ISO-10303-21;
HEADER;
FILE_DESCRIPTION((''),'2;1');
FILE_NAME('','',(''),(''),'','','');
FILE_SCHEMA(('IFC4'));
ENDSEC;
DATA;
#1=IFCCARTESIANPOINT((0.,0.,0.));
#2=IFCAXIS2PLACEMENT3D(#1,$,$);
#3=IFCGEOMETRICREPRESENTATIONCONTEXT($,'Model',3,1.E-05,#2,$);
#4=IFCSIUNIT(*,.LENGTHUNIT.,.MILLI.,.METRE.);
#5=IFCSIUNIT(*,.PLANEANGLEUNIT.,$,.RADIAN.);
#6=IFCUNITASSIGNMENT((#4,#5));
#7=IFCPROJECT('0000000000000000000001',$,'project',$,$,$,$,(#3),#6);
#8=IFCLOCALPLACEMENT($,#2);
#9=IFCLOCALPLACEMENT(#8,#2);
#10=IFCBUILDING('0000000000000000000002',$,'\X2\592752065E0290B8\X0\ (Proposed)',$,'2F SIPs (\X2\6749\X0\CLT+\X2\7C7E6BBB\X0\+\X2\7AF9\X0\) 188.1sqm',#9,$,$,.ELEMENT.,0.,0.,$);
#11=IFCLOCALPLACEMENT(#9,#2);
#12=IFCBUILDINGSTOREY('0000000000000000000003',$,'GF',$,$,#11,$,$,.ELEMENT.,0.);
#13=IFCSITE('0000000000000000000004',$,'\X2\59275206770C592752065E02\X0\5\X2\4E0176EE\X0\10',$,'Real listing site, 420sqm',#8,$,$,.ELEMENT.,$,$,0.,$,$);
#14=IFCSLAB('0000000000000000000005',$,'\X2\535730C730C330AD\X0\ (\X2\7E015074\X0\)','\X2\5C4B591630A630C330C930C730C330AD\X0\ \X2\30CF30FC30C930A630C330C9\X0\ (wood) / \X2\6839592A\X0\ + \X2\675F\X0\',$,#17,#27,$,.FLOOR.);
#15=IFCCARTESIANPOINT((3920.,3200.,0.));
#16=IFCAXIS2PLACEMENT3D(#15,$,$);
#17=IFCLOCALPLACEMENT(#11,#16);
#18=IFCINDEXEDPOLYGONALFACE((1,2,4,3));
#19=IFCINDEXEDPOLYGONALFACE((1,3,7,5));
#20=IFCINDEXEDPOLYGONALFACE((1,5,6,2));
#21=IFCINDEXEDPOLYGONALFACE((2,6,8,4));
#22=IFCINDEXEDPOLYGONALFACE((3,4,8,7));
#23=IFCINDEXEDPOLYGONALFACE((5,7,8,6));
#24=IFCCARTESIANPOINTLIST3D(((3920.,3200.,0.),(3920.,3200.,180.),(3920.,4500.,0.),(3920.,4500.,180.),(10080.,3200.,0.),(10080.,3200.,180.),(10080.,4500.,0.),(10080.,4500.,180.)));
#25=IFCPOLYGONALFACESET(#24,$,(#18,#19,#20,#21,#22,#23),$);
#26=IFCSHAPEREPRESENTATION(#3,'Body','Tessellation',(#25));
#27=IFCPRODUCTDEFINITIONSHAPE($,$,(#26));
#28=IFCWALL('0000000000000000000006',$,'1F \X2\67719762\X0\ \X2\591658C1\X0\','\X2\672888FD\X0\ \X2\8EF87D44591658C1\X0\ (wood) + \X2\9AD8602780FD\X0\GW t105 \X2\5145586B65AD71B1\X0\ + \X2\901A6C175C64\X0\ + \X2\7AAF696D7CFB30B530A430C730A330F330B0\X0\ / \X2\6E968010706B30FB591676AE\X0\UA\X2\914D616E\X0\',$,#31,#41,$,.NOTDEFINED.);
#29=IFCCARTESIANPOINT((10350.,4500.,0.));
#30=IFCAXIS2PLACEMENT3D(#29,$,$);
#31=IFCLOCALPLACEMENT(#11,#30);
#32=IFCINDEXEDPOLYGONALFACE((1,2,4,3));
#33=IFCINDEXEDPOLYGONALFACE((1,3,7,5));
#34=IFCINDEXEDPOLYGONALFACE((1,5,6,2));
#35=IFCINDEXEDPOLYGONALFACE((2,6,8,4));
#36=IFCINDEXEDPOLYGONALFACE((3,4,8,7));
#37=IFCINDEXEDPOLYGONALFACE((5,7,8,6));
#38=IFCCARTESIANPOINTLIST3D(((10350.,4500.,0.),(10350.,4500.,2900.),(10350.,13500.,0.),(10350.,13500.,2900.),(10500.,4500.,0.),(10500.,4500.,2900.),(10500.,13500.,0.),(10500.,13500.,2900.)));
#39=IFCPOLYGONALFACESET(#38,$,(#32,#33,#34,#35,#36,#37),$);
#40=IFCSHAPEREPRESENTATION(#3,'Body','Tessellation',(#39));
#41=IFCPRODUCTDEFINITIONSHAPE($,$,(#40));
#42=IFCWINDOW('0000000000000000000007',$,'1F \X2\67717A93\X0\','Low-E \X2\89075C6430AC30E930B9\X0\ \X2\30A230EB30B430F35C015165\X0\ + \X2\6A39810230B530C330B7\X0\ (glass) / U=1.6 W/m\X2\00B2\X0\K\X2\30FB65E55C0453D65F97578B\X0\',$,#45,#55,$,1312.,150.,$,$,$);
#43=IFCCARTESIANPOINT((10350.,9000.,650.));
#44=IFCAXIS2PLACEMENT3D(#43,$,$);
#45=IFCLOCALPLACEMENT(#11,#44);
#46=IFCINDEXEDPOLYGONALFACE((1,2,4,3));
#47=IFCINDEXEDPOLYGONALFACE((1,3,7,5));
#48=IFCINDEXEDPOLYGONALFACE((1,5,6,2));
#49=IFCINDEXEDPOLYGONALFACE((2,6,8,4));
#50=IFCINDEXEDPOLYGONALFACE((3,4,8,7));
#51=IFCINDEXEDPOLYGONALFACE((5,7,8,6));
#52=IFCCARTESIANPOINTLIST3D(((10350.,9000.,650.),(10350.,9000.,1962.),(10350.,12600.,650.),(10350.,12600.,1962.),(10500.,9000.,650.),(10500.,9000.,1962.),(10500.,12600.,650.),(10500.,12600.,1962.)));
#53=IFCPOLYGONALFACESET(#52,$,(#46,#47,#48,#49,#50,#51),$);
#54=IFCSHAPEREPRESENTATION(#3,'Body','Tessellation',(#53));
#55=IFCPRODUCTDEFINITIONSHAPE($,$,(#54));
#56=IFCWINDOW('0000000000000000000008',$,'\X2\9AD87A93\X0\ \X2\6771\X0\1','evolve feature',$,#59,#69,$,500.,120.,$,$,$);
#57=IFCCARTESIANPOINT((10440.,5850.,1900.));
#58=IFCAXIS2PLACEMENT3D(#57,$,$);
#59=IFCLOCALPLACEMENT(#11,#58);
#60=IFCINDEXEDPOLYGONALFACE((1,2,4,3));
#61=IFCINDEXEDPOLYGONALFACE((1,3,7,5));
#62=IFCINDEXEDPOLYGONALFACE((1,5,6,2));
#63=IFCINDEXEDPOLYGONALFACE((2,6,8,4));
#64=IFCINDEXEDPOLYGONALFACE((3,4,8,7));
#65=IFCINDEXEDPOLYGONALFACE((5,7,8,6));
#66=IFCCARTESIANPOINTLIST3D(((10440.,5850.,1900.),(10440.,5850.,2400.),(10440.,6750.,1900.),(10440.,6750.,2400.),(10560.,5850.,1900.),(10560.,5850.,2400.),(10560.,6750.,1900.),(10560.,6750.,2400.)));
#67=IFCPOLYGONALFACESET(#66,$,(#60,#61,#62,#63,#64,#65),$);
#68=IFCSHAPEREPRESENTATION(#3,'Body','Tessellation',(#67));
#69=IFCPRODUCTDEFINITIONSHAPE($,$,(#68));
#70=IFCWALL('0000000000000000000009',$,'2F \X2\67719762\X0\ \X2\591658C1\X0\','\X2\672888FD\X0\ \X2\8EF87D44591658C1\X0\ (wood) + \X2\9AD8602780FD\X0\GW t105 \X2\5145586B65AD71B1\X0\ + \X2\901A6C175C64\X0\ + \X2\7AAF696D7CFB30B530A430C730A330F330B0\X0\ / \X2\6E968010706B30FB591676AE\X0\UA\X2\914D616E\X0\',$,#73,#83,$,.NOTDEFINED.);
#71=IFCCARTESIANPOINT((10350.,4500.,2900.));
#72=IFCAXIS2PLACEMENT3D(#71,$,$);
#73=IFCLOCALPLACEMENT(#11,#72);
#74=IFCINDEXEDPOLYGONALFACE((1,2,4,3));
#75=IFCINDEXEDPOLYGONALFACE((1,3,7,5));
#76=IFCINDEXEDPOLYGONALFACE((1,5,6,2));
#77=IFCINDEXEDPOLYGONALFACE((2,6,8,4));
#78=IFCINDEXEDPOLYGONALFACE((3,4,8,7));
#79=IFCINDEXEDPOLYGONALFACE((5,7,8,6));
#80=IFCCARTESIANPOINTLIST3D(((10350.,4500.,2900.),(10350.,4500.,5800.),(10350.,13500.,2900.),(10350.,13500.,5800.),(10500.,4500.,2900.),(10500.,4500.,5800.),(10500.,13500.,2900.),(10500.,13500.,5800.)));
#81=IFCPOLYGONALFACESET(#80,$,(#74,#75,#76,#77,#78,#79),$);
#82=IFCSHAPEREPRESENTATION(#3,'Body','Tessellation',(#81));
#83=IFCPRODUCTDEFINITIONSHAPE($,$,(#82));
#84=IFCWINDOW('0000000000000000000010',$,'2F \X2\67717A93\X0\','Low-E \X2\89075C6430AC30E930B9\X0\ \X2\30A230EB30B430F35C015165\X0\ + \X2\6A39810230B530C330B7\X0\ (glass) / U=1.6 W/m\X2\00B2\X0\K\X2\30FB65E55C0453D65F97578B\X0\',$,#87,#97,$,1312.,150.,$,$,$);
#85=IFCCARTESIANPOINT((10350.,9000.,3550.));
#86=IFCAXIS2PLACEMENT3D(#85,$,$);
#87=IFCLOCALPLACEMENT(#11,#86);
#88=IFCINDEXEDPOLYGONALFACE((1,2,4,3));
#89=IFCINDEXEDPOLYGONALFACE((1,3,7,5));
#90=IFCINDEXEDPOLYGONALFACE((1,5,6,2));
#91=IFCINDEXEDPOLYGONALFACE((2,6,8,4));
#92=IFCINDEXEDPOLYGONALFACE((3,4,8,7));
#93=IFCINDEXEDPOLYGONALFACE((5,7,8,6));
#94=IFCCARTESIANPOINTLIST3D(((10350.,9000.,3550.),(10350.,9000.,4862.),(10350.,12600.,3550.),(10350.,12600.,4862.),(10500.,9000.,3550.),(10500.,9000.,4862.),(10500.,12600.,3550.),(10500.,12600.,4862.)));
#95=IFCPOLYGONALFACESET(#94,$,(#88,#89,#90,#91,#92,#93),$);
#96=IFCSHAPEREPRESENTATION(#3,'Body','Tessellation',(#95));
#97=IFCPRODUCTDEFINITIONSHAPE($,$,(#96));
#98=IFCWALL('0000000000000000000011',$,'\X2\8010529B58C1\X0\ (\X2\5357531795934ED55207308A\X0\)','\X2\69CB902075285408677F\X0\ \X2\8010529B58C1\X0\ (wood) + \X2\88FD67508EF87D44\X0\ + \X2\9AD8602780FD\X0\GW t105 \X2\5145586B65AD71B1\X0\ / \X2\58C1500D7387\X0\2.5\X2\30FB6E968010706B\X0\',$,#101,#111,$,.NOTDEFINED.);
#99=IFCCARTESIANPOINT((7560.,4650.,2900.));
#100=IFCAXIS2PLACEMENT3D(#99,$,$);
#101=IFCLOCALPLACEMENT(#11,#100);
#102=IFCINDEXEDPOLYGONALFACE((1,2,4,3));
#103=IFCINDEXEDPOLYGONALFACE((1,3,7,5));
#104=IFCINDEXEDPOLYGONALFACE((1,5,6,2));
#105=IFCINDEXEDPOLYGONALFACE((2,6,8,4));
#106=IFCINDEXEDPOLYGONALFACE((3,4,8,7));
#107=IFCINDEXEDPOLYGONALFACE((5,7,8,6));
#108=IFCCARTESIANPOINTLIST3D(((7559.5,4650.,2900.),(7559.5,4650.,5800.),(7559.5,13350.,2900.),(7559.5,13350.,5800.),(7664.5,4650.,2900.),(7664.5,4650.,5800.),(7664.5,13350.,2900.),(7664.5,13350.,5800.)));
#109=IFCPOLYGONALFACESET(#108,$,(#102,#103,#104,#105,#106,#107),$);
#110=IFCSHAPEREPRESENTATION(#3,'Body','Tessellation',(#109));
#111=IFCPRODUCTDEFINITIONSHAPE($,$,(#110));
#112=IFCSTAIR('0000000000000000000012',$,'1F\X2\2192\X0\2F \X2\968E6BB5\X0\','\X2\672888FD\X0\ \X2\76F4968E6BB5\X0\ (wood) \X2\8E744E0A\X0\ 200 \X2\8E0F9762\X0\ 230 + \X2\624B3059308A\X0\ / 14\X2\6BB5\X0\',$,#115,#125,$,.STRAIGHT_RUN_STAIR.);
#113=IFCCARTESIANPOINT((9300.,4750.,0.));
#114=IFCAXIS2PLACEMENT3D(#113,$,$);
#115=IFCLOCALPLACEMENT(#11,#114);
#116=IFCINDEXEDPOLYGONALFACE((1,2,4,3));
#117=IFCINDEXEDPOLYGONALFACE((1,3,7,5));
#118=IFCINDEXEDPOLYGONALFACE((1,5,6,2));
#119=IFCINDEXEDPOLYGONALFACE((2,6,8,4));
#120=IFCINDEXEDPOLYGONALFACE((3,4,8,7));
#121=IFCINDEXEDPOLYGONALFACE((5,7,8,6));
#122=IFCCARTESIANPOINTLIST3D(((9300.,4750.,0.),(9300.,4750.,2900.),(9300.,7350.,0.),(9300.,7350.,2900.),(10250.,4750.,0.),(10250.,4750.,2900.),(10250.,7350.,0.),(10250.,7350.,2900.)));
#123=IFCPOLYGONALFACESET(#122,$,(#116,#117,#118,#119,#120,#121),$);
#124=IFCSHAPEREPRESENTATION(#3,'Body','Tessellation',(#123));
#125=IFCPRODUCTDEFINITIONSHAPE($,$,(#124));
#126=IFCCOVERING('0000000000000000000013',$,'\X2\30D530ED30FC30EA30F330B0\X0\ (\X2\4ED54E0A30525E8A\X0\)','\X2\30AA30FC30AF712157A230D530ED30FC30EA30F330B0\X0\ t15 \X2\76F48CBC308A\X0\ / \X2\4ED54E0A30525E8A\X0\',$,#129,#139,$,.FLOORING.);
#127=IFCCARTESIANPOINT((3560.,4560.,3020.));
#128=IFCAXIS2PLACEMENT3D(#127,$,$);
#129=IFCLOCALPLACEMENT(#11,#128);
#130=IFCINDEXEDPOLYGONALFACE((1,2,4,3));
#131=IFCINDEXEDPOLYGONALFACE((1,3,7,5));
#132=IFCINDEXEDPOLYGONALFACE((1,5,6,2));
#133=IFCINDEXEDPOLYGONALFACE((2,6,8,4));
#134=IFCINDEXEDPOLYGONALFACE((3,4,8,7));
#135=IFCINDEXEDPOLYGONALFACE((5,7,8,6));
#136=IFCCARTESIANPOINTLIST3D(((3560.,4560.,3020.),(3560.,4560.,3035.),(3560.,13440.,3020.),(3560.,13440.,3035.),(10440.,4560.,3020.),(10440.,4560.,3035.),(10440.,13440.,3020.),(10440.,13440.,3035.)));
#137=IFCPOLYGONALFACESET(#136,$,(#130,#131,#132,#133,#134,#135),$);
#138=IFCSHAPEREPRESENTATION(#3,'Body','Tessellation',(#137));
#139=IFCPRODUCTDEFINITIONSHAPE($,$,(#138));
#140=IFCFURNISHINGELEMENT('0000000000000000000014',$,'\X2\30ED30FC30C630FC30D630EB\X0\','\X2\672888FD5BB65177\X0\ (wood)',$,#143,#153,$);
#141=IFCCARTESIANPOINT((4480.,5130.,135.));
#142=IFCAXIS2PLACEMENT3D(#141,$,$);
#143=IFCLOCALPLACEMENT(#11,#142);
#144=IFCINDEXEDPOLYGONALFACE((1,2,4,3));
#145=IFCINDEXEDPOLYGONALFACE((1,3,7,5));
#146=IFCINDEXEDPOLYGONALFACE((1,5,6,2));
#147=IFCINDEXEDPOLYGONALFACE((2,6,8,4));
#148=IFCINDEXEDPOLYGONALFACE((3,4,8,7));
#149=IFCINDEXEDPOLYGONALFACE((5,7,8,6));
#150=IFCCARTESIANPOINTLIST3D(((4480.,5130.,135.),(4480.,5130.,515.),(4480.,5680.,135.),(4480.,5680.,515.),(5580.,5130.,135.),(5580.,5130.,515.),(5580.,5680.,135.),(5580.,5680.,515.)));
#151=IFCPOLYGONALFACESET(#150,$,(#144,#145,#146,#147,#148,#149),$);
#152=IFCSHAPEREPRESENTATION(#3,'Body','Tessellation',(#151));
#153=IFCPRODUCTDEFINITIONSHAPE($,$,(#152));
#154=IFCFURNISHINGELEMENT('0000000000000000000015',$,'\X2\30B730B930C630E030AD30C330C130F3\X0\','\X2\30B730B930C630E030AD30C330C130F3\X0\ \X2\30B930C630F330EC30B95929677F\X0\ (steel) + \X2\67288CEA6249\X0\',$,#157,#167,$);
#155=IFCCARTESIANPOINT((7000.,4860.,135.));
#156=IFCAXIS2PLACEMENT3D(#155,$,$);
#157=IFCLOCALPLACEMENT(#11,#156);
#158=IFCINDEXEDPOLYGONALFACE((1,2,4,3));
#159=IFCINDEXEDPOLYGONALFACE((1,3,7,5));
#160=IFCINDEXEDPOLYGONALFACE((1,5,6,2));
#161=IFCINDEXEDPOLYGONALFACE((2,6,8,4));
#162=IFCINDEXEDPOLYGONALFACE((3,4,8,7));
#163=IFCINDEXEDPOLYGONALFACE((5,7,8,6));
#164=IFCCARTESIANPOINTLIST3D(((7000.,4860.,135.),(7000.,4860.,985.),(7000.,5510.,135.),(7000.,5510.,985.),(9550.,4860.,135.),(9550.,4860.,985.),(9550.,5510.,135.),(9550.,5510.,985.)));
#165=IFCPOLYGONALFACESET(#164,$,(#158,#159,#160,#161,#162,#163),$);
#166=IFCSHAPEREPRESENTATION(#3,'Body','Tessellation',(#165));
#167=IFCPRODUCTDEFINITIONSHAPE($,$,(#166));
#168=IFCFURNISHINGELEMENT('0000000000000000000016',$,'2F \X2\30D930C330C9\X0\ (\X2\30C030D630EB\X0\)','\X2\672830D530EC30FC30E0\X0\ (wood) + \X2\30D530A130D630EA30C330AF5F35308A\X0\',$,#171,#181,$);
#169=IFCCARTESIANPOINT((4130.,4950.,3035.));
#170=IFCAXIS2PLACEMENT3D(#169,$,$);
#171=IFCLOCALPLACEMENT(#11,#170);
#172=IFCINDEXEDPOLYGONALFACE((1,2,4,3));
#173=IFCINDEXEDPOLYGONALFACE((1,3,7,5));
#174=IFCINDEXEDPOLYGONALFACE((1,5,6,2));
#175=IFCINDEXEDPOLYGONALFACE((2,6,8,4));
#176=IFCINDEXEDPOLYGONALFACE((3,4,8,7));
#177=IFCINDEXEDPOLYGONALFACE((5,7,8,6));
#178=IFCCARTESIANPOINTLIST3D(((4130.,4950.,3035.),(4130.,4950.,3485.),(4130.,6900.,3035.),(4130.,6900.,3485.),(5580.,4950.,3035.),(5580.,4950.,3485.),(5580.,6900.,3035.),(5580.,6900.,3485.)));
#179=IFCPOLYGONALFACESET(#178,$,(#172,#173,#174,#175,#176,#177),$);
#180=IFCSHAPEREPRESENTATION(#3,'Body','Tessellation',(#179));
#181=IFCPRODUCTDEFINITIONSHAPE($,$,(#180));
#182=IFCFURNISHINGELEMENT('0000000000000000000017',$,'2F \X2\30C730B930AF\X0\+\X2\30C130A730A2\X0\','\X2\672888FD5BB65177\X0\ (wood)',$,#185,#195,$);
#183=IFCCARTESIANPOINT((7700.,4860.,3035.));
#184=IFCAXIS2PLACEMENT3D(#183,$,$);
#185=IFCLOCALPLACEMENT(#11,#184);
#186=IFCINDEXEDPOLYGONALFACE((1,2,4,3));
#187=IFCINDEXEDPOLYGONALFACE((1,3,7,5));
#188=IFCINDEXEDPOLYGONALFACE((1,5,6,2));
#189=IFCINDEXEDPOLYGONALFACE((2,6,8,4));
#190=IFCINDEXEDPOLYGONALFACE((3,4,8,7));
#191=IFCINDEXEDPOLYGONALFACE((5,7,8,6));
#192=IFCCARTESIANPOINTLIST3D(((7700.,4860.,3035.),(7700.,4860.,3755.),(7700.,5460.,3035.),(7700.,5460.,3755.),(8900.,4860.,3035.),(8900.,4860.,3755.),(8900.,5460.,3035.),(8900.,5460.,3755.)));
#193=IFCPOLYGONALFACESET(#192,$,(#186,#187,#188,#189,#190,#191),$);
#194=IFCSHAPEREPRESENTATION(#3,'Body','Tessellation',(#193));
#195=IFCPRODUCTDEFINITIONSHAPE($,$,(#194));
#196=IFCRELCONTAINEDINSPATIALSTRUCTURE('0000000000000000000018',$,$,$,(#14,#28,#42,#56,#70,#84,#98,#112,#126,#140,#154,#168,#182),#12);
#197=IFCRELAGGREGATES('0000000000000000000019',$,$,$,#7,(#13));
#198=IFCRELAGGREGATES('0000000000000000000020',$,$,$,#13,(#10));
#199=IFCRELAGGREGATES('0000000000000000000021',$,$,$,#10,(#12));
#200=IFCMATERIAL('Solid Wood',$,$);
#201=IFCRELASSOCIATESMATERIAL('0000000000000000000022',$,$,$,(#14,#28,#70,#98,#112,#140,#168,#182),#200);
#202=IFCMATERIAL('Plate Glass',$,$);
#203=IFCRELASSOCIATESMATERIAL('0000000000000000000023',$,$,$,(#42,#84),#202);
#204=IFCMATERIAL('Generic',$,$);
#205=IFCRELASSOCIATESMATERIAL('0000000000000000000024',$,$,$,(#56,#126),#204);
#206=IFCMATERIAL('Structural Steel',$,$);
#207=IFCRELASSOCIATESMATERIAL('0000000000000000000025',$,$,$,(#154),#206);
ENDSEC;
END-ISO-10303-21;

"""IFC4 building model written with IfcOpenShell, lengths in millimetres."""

from ifc_helpers import new_model, si_unit, frame, frame_2d, origin, place, context, project, spatial, rectangle, extrude, material, element, fill, save


model = new_model("IFC4")

# Units and contexts
model_context = context("Model", 3, precision=1e-05, world=origin())
ifc_project = project(units=[si_unit("LENGTHUNIT", "METRE", prefix="MILLI"), si_unit("PLANEANGLEUNIT", "RADIAN")], contexts=[model_context])

# Site, building, storey
site_placement = place(None, origin())
site = spatial("IfcSite", under=ifc_project, at=site_placement, Name="大分県大分市5丁目10", ObjectType="Real listing site, 420sqm", CompositionType="ELEMENT", RefElevation=0.0)
building_placement = place(site_placement, origin())
building = spatial("IfcBuilding", under=site, at=building_placement, Name="大分市邸 (Proposed)", ObjectType="2F SIPs (杉CLT+籾殻+竹) 188.1sqm", CompositionType="ELEMENT", ElevationOfRefHeight=0.0, ElevationOfTerrain=0.0)
storey_placement = place(building_placement, origin())
storey = spatial("IfcBuildingStorey", under=building, at=storey_placement, Name="GF", CompositionType="ELEMENT", Elevation=0.0)

# Slab
ifc_material_1 = material(Name="Solid Wood")
slab_placement = place(storey_placement, frame((3920.0, 3200.0, 0.0)))
element("IfcSlab", 1, at=slab_placement, inside=storey, material=ifc_material_1, Name="南デッキ (縁側)", Description="屋外ウッドデッキ ハードウッド (wood) / 根太 + 束", PredefinedType="FLOOR", context=model_context, shape_type="SweptSolid", body=[
    extrude(rectangle(XDim=6160.0, YDim=1300.0, at=frame_2d((3080.0, 650.0))), frame((3920.0, 3200.0, 0.0)), (0.0, 0.0, 1.0), 180.0),
])

# Wall, openings, windows
wall_1_placement = place(storey_placement, frame((10350.0, 4500.0, 0.0)))
wall_1 = element("IfcWall", 2, at=wall_1_placement, inside=storey, material=ifc_material_1, Name="1F 東面 外壁", Description="木製 軸組外壁 (wood) + 高性能GW t105 充填断熱 + 通気層 + 窯業系サイディング / 準耐火・外皮UA配慮", PredefinedType="NOTDEFINED", context=model_context, shape_type="SweptSolid", body=[
    extrude(rectangle(XDim=150.0, YDim=9000.0, at=frame_2d((75.0, 4500.0))), frame((10350.0, 4500.0, 0.0)), (0.0, 0.0, 1.0), 2900.0),
])
opening_1_placement = place(storey_placement, frame((10350.0, 9000.0, 650.0)))
opening_1 = element("IfcOpeningElement", 3, at=opening_1_placement, cuts=wall_1, PredefinedType="NOTDEFINED", context=model_context, shape_type="SweptSolid", body=[
    extrude(rectangle(XDim=150.0, YDim=3600.0, at=frame_2d((75.0, 1800.0))), frame((10350.0, 9000.0, 650.0)), (0.0, 0.0, 1.0), 1312.0),
])
opening_2_placement = place(storey_placement, frame((10440.0, 5850.0, 1900.0)))
opening_2 = element("IfcOpeningElement", 4, at=opening_2_placement, cuts=wall_1, PredefinedType="NOTDEFINED", context=model_context, shape_type="SweptSolid", body=[
    extrude(rectangle(XDim=120.0, YDim=900.0, at=frame_2d((60.0, 450.0))), frame((10440.0, 5850.0, 1900.0)), (0.0, 0.0, 1.0), 500.0),
])
ifc_material_2 = material(Name="Plate Glass")
window_1_placement = place(storey_placement, frame((10350.0, 9000.0, 650.0)))
window_1 = element("IfcWindow", 5, at=window_1_placement, inside=storey, material=ifc_material_2, Name="1F 東窓", Description="Low-E 複層ガラス アルゴン封入 + 樹脂サッシ (glass) / U=1.6 W/m²K・日射取得型", OverallHeight=1312.0, OverallWidth=150.0, context=model_context, shape_type="SweptSolid", body=[
    extrude(rectangle(XDim=150.0, YDim=3600.0, at=frame_2d((75.0, 1800.0))), frame((10350.0, 9000.0, 650.0)), (0.0, 0.0, 1.0), 1312.0),
])
fill(opening_1, window_1)
ifc_material_3 = material(Name="Generic")
window_2_placement = place(storey_placement, frame((10440.0, 5850.0, 1900.0)))
window_2 = element("IfcWindow", 6, at=window_2_placement, inside=storey, material=ifc_material_3, Name="高窓 東1", Description="evolve feature", OverallHeight=500.0, OverallWidth=120.0, context=model_context, shape_type="SweptSolid", body=[
    extrude(rectangle(XDim=120.0, YDim=900.0, at=frame_2d((60.0, 450.0))), frame((10440.0, 5850.0, 1900.0)), (0.0, 0.0, 1.0), 500.0),
])
fill(opening_2, window_2)

# Wall, opening, window
wall_2_placement = place(storey_placement, frame((10350.0, 4500.0, 2900.0)))
wall_2 = element("IfcWall", 7, at=wall_2_placement, inside=storey, material=ifc_material_1, Name="2F 東面 外壁", Description="木製 軸組外壁 (wood) + 高性能GW t105 充填断熱 + 通気層 + 窯業系サイディング / 準耐火・外皮UA配慮", PredefinedType="NOTDEFINED", context=model_context, shape_type="SweptSolid", body=[
    extrude(rectangle(XDim=150.0, YDim=9000.0, at=frame_2d((75.0, 4500.0))), frame((10350.0, 4500.0, 2900.0)), (0.0, 0.0, 1.0), 2900.0),
])
opening_3_placement = place(storey_placement, frame((10350.0, 9000.0, 3550.0)))
opening_3 = element("IfcOpeningElement", 8, at=opening_3_placement, cuts=wall_2, PredefinedType="NOTDEFINED", context=model_context, shape_type="SweptSolid", body=[
    extrude(rectangle(XDim=150.0, YDim=3600.0, at=frame_2d((75.0, 1800.0))), frame((10350.0, 9000.0, 3550.0)), (0.0, 0.0, 1.0), 1312.0),
])
window_3_placement = place(storey_placement, frame((10350.0, 9000.0, 3550.0)))
window_3 = element("IfcWindow", 9, at=window_3_placement, inside=storey, material=ifc_material_2, Name="2F 東窓", Description="Low-E 複層ガラス アルゴン封入 + 樹脂サッシ (glass) / U=1.6 W/m²K・日射取得型", OverallHeight=1312.0, OverallWidth=150.0, context=model_context, shape_type="SweptSolid", body=[
    extrude(rectangle(XDim=150.0, YDim=3600.0, at=frame_2d((75.0, 1800.0))), frame((10350.0, 9000.0, 3550.0)), (0.0, 0.0, 1.0), 1312.0),
])
fill(opening_3, window_3)

# Wall
wall_3_placement = place(storey_placement, frame((7560.0, 4650.0, 2900.0)))
element("IfcWall", 10, at=wall_3_placement, inside=storey, material=ifc_material_1, Name="耐力壁 (南北間仕切り)", Description="構造用合板 耐力壁 (wood) + 製材軸組 + 高性能GW t105 充填断熱 / 壁倍率2.5・準耐火", PredefinedType="NOTDEFINED", context=model_context, shape_type="SweptSolid", body=[
    extrude(rectangle(XDim=105.0, YDim=8700.0, at=frame_2d((52.0, 4350.0))), frame((7560.0, 4650.0, 2900.0)), (0.0, 0.0, 1.0), 2900.0),
])

# Stair
stair_placement = place(storey_placement, frame((9300.0, 4750.0, 0.0)))
element("IfcStair", 11, at=stair_placement, inside=storey, material=ifc_material_1, Name="1F→2F 階段", Description="木製 直階段 (wood) 蹴上 200 踏面 230 + 手すり / 14段", PredefinedType="STRAIGHT_RUN_STAIR", context=model_context, shape_type="SweptSolid", body=[
    extrude(rectangle(XDim=950.0, YDim=2600.0, at=frame_2d((475.0, 1300.0))), frame((9300.0, 4750.0, 0.0)), (0.0, 0.0, 1.0), 2900.0),
])

# Covering
covering_placement = place(storey_placement, frame((3560.0, 4560.0, 3020.0)))
element("IfcCovering", 12, at=covering_placement, inside=storey, material=ifc_material_3, Name="フローリング (仕上げ床)", Description="オーク無垢フローリング t15 直貼り / 仕上げ床", PredefinedType="FLOORING", context=model_context, shape_type="SweptSolid", body=[
    extrude(rectangle(XDim=6880.0, YDim=8880.0, at=frame_2d((3440.0, 4440.0))), frame((3560.0, 4560.0, 3020.0)), (0.0, 0.0, 1.0), 15.0),
])

# Furnishing elements
furnishing_1_placement = place(storey_placement, frame((4480.0, 5130.0, 135.0)))
element("IfcFurnishingElement", 13, at=furnishing_1_placement, inside=storey, material=ifc_material_1, Name="ローテーブル", Description="木製家具 (wood)", context=model_context, shape_type="SweptSolid", body=[
    extrude(rectangle(XDim=1100.0, YDim=550.0, at=frame_2d((550.0, 275.0))), frame((4480.0, 5130.0, 135.0)), (0.0, 0.0, 1.0), 380.0),
])
ifc_material_4 = material(Name="Structural Steel")
furnishing_2_placement = place(storey_placement, frame((7000.0, 4860.0, 135.0)))
element("IfcFurnishingElement", 14, at=furnishing_2_placement, inside=storey, material=ifc_material_4, Name="システムキッチン", Description="システムキッチン ステンレス天板 (steel) + 木質扉", context=model_context, shape_type="SweptSolid", body=[
    extrude(rectangle(XDim=2550.0, YDim=650.0, at=frame_2d((1275.0, 325.0))), frame((7000.0, 4860.0, 135.0)), (0.0, 0.0, 1.0), 850.0),
])
furnishing_3_placement = place(storey_placement, frame((4130.0, 4950.0, 3035.0)))
element("IfcFurnishingElement", 15, at=furnishing_3_placement, inside=storey, material=ifc_material_1, Name="2F ベッド (ダブル)", Description="木フレーム (wood) + ファブリック張り", context=model_context, shape_type="SweptSolid", body=[
    extrude(rectangle(XDim=1450.0, YDim=1950.0, at=frame_2d((725.0, 975.0))), frame((4130.0, 4950.0, 3035.0)), (0.0, 0.0, 1.0), 450.0),
])
furnishing_4_placement = place(storey_placement, frame((7700.0, 4860.0, 3035.0)))
element("IfcFurnishingElement", 16, at=furnishing_4_placement, inside=storey, material=ifc_material_1, Name="2F デスク+チェア", Description="木製家具 (wood)", context=model_context, shape_type="SweptSolid", body=[
    extrude(rectangle(XDim=1200.0, YDim=600.0, at=frame_2d((600.0, 300.0))), frame((7700.0, 4860.0, 3035.0)), (0.0, 0.0, 1.0), 720.0),
])

save(model, "model.ifc")
